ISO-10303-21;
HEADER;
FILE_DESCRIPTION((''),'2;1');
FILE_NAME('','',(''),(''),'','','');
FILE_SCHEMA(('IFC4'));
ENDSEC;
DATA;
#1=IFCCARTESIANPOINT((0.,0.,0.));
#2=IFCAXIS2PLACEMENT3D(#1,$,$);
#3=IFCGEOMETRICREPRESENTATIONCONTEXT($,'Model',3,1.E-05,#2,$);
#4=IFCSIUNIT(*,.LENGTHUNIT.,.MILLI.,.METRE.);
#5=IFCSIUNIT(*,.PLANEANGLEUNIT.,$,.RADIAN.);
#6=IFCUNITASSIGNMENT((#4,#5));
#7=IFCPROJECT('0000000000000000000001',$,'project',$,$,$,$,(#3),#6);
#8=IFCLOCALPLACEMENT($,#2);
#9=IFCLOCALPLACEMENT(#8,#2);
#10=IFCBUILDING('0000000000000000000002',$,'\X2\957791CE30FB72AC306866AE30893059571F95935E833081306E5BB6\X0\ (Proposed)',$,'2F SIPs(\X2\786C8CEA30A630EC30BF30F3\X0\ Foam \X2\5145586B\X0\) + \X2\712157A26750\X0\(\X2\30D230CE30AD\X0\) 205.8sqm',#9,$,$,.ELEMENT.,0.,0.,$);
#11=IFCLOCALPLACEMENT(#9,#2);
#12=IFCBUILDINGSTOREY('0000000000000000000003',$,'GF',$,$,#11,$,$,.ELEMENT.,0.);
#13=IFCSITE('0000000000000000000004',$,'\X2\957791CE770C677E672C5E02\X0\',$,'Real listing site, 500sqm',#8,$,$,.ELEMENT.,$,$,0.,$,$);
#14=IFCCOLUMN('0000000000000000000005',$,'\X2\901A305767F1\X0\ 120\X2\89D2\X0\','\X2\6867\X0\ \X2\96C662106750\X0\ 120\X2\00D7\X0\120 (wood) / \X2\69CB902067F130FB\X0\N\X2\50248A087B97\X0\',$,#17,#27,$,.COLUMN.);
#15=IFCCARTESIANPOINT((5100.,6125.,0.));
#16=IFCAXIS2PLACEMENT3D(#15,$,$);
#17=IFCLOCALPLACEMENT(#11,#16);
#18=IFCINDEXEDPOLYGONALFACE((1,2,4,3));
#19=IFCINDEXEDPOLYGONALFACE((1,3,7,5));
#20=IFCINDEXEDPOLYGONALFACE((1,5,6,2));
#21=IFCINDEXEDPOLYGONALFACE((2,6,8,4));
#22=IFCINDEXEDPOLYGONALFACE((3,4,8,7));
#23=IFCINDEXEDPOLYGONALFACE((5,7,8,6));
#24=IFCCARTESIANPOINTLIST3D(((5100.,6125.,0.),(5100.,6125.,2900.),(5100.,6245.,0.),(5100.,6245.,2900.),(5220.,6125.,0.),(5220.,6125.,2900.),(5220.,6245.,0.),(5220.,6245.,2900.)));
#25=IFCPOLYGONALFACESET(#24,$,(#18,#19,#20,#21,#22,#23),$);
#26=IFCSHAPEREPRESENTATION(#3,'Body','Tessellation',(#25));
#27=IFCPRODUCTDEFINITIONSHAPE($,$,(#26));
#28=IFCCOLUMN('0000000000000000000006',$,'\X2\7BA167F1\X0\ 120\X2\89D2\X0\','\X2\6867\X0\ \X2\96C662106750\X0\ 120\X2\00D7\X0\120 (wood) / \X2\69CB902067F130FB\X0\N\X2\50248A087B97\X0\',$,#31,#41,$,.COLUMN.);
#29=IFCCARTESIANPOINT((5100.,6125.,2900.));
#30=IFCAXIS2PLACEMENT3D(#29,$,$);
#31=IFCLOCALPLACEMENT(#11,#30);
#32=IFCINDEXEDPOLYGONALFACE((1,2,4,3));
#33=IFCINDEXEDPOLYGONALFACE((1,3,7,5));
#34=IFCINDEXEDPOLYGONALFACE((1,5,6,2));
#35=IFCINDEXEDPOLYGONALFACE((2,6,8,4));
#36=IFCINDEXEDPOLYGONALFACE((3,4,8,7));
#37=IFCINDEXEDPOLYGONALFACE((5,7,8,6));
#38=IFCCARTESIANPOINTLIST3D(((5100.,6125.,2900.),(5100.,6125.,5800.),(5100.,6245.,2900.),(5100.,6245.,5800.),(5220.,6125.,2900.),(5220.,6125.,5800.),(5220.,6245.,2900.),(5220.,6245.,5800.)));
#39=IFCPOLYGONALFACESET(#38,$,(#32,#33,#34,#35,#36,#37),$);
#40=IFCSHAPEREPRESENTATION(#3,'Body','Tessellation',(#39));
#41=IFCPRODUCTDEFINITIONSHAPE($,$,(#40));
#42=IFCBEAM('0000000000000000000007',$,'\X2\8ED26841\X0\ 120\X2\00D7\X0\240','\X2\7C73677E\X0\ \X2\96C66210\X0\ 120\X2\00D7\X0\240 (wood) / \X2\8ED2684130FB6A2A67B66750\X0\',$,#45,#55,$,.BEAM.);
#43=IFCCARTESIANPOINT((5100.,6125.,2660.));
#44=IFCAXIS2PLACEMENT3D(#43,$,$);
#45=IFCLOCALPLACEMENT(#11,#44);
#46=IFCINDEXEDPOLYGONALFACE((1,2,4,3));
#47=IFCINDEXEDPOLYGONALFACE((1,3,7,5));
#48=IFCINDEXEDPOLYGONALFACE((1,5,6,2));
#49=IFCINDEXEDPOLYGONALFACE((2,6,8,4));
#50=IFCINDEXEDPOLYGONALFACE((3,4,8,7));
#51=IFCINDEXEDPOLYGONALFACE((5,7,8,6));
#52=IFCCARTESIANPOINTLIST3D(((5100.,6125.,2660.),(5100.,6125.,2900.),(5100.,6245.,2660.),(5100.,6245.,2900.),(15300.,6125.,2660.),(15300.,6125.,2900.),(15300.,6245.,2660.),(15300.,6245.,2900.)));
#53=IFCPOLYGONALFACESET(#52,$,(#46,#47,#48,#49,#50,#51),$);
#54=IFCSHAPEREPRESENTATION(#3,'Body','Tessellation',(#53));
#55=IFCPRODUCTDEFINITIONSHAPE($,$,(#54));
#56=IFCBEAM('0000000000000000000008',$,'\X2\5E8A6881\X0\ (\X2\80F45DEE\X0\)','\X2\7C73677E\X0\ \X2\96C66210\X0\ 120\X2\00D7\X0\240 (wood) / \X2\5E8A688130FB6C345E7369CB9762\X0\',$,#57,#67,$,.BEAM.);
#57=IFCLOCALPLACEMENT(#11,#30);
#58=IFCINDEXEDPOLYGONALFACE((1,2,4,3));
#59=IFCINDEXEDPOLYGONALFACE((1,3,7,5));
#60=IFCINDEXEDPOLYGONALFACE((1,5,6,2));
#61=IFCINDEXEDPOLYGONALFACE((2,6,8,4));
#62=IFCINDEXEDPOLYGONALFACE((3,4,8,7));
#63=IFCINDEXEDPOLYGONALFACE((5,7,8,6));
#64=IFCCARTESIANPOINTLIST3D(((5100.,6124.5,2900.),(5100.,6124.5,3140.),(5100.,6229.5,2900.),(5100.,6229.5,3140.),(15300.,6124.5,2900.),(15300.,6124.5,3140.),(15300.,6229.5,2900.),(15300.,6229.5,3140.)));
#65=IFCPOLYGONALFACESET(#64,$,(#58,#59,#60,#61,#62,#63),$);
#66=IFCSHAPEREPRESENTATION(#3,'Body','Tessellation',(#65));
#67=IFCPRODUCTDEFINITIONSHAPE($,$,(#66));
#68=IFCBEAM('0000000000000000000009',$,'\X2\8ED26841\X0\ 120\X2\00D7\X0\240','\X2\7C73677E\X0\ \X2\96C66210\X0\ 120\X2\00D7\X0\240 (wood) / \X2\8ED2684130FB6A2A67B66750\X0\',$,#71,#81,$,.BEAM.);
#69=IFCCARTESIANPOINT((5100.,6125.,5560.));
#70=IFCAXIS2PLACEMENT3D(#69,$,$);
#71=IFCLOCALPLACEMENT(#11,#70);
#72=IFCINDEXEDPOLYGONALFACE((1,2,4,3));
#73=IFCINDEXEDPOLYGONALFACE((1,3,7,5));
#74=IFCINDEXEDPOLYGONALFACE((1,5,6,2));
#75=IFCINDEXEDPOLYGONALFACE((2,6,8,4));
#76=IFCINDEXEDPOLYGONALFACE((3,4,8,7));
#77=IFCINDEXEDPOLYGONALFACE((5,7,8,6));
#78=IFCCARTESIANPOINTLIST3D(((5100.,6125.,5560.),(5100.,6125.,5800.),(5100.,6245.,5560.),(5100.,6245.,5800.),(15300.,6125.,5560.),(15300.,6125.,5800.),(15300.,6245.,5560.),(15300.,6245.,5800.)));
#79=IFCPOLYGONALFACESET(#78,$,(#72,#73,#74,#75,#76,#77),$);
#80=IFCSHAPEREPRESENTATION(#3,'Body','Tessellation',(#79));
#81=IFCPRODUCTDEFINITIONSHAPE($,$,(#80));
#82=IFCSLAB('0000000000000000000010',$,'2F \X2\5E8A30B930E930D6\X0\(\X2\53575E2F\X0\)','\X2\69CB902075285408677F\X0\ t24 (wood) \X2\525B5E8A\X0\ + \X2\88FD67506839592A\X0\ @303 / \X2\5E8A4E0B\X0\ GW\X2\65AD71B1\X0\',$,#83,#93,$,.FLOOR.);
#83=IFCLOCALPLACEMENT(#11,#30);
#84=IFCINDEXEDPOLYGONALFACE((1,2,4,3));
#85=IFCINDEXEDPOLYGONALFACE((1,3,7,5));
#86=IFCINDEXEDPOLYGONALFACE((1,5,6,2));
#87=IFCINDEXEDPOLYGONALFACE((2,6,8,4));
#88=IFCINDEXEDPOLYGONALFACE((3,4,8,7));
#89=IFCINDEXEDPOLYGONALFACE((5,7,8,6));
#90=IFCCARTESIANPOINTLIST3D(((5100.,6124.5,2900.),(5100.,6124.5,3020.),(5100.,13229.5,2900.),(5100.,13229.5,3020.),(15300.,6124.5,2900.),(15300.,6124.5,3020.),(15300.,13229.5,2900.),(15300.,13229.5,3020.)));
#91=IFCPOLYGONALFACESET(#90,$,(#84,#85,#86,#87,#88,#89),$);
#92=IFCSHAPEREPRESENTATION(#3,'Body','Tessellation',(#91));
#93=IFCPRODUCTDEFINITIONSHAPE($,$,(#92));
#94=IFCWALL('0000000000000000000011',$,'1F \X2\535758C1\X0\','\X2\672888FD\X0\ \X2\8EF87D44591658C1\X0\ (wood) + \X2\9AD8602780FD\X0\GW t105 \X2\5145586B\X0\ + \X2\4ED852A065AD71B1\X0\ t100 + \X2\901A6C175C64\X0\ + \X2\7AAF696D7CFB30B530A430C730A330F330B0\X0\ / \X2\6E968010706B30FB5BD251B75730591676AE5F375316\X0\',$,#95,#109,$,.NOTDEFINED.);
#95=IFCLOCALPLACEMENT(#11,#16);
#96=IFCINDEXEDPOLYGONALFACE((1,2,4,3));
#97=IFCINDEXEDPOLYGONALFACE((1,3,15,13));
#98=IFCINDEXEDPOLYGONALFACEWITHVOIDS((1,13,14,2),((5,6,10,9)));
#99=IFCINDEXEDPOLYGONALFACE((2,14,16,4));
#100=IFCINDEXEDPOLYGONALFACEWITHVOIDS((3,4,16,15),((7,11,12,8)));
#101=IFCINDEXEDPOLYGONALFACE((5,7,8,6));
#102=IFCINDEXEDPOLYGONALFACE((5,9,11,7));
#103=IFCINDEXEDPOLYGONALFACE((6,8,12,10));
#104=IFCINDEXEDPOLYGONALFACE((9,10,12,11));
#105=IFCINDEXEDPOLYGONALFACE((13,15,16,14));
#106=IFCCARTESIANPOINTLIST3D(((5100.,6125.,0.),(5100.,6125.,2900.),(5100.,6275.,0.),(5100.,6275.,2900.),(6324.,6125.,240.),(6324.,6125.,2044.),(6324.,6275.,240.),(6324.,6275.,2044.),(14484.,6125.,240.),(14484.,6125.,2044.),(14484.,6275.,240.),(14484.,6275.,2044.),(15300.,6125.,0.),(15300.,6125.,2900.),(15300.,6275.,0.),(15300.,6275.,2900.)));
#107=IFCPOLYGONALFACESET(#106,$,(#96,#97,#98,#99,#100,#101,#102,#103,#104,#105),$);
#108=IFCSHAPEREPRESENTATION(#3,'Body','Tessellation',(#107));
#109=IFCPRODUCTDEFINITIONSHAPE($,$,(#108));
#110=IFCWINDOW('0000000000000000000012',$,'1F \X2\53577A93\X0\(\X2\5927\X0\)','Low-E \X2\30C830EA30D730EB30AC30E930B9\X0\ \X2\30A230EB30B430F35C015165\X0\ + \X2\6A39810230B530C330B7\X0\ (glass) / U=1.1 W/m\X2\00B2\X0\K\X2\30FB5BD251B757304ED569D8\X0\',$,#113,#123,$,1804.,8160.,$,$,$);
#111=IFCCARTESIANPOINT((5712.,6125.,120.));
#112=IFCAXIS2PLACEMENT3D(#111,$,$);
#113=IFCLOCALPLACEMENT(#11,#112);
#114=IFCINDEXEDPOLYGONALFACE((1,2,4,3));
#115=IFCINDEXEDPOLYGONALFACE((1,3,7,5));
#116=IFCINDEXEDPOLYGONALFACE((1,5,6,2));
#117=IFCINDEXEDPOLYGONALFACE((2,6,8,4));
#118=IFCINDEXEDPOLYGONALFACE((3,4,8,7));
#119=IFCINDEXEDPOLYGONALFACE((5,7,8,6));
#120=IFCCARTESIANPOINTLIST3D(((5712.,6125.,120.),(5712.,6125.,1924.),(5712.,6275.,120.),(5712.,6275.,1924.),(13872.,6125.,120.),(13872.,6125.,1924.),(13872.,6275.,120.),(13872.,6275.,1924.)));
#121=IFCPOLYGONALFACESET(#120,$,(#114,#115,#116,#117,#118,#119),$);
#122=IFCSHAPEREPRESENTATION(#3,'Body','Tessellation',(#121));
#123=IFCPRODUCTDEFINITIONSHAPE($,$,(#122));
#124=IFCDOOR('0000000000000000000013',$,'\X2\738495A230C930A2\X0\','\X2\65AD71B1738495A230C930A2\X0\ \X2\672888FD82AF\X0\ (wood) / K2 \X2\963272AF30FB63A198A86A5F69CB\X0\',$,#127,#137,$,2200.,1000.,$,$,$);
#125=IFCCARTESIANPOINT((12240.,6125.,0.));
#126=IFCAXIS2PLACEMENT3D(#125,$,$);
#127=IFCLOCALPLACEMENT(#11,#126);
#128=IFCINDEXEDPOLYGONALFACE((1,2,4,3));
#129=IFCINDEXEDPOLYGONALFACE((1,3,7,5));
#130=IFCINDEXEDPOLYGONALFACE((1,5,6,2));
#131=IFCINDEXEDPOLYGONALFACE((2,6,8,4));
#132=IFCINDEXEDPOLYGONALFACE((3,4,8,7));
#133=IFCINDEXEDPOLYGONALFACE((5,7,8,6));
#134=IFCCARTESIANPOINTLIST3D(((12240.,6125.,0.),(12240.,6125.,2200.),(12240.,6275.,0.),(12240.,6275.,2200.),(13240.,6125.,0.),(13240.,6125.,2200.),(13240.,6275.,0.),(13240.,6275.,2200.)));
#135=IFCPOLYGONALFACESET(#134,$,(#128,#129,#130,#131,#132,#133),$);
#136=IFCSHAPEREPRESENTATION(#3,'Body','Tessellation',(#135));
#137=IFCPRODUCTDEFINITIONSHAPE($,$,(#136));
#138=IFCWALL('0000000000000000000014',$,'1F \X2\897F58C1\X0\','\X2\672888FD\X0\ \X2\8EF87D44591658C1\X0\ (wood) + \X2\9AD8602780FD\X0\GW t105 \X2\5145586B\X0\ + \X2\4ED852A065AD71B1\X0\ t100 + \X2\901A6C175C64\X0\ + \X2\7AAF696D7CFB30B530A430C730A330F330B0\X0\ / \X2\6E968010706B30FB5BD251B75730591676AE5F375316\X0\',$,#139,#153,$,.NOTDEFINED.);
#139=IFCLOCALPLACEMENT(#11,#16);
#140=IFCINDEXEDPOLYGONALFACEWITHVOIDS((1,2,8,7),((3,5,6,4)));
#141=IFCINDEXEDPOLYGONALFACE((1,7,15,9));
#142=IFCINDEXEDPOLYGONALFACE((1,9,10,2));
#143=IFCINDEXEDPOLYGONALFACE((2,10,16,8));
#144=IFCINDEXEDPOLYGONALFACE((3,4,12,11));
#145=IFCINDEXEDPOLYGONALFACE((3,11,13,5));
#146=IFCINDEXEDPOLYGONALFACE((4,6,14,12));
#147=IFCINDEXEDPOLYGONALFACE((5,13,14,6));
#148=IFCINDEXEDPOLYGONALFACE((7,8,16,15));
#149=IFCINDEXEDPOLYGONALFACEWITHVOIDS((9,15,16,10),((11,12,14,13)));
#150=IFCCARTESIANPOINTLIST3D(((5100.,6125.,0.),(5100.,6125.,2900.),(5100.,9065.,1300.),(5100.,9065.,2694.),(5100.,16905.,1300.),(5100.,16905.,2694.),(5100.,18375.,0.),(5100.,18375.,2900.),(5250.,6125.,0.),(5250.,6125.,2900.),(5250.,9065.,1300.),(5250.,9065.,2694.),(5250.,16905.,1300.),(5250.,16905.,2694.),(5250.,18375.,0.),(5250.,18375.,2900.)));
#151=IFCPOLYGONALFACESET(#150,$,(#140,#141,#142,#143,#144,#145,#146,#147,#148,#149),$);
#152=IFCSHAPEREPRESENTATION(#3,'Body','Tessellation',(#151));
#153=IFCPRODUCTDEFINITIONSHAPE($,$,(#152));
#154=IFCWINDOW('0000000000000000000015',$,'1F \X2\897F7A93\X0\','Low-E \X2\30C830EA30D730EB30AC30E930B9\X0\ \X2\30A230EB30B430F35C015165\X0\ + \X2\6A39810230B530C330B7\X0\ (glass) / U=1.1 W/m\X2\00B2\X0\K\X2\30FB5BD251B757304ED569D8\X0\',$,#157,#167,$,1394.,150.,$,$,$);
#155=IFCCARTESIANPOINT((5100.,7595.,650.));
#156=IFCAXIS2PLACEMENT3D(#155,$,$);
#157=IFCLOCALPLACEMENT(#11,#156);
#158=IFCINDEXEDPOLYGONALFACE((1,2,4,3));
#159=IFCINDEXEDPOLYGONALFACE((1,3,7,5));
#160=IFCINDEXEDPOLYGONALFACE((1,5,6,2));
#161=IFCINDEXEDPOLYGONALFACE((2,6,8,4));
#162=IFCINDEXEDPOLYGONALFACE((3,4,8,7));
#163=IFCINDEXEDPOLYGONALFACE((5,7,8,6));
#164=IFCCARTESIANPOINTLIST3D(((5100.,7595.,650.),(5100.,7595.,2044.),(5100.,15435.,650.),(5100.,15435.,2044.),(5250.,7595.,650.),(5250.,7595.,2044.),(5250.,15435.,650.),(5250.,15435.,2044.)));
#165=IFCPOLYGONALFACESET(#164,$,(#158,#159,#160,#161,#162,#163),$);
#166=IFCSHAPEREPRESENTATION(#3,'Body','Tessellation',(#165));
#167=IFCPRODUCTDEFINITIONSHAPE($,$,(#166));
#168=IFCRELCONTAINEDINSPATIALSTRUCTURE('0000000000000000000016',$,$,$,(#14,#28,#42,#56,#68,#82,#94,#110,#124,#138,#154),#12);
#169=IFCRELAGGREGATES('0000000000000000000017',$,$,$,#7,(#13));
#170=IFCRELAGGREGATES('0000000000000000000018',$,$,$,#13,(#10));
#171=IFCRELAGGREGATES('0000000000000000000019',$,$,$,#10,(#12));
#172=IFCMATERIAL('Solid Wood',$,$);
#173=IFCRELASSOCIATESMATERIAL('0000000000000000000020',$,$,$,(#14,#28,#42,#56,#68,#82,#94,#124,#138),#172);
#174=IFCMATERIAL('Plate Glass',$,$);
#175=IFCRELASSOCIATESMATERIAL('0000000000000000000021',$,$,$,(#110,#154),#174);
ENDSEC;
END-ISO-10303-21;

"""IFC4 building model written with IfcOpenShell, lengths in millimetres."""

from ifc_helpers import new_model, si_unit, frame, frame_2d, origin, place, context, project, spatial, rectangle, extrude, material, element, fill, save


model = new_model("IFC4")

# Units and contexts
model_context = context("Model", 3, precision=1e-05, world=origin())
ifc_project = project(units=[si_unit("LENGTHUNIT", "METRE", prefix="MILLI"), si_unit("PLANEANGLEUNIT", "RADIAN")], contexts=[model_context])

# Site, building, storey
site_placement = place(None, origin())
site = spatial("IfcSite", under=ifc_project, at=site_placement, Name="長野県松本市", ObjectType="Real listing site, 500sqm", CompositionType="ELEMENT", RefElevation=0.0)
building_placement = place(site_placement, origin())
building = spatial("IfcBuilding", under=site, at=building_placement, Name="長野・犬と暮らす土間広めの家 (Proposed)", ObjectType="2F SIPs(硬質ウレタン Foam 充填) + 無垢材(ヒノキ) 205.8sqm", CompositionType="ELEMENT", ElevationOfRefHeight=0.0, ElevationOfTerrain=0.0)
storey_placement = place(building_placement, origin())
storey = spatial("IfcBuildingStorey", under=building, at=storey_placement, Name="GF", CompositionType="ELEMENT", Elevation=0.0)

# Columns
ifc_material_1 = material(Name="Solid Wood")
column_1_placement = place(storey_placement, frame((5100.0, 6125.0, 0.0)))
element("IfcColumn", 1, at=column_1_placement, inside=storey, material=ifc_material_1, Name="通し柱 120角", Description="桧 集成材 120×120 (wood) / 構造柱・N値計算", PredefinedType="COLUMN", context=model_context, shape_type="SweptSolid", body=[
    extrude(rectangle(XDim=120.0, YDim=120.0, at=frame_2d((60.0, 60.0))), frame((5100.0, 6125.0, 0.0)), (0.0, 0.0, 1.0), 2900.0),
])
column_2_placement = place(storey_placement, frame((5100.0, 6125.0, 2900.0)))
element("IfcColumn", 2, at=column_2_placement, inside=storey, material=ifc_material_1, Name="管柱 120角", Description="桧 集成材 120×120 (wood) / 構造柱・N値計算", PredefinedType="COLUMN", context=model_context, shape_type="SweptSolid", body=[
    extrude(rectangle(XDim=120.0, YDim=120.0, at=frame_2d((60.0, 60.0))), frame((5100.0, 6125.0, 2900.0)), (0.0, 0.0, 1.0), 2900.0),
])

# Beams
beam_1_placement = place(storey_placement, frame((5100.0, 6125.0, 2660.0)))
element("IfcBeam", 3, at=beam_1_placement, inside=storey, material=ifc_material_1, Name="軒桁 120×240", Description="米松 集成 120×240 (wood) / 軒桁・横架材", PredefinedType="BEAM", context=model_context, shape_type="SweptSolid", body=[
    extrude(rectangle(XDim=10200.0, YDim=120.0, at=frame_2d((5100.0, 60.0))), frame((5100.0, 6125.0, 2660.0)), (0.0, 0.0, 1.0), 240.0),
])
beam_2_placement = place(storey_placement, frame((5100.0, 6125.0, 2900.0)))
element("IfcBeam", 4, at=beam_2_placement, inside=storey, material=ifc_material_1, Name="床梁 (胴差)", Description="米松 集成 120×240 (wood) / 床梁・水平構面", PredefinedType="BEAM", context=model_context, shape_type="SweptSolid", body=[
    extrude(rectangle(XDim=10200.0, YDim=105.0, at=frame_2d((5100.0, 52.0))), frame((5100.0, 6125.0, 2900.0)), (0.0, 0.0, 1.0), 240.0),
])
beam_3_placement = place(storey_placement, frame((5100.0, 6125.0, 5560.0)))
element("IfcBeam", 5, at=beam_3_placement, inside=storey, material=ifc_material_1, Name="軒桁 120×240", Description="米松 集成 120×240 (wood) / 軒桁・横架材", PredefinedType="BEAM", context=model_context, shape_type="SweptSolid", body=[
    extrude(rectangle(XDim=10200.0, YDim=120.0, at=frame_2d((5100.0, 60.0))), frame((5100.0, 6125.0, 5560.0)), (0.0, 0.0, 1.0), 240.0),
])

# Slab
slab_1_placement = place(storey_placement, frame((5100.0, 6125.0, 2900.0)))
element("IfcSlab", 6, at=slab_1_placement, inside=storey, material=ifc_material_1, Name="2F 床スラブ(南帯)", Description="構造用合板 t24 (wood) 剛床 + 製材根太 @303 / 床下 GW断熱", PredefinedType="FLOOR", context=model_context, shape_type="SweptSolid", body=[
    extrude(rectangle(XDim=10200.0, YDim=7105.0, at=frame_2d((5100.0, 3552.0))), frame((5100.0, 6125.0, 2900.0)), (0.0, 0.0, 1.0), 120.0),
])

# Wall, openings, window, door
wall_1_placement = place(storey_placement, frame((5100.0, 6125.0, 0.0)))
wall_1 = element("IfcWall", 7, at=wall_1_placement, inside=storey, material=ifc_material_1, Name="1F 南壁", Description="木製 軸組外壁 (wood) + 高性能GW t105 充填 + 付加断熱 t100 + 通気層 + 窯業系サイディング / 準耐火・寒冷地外皮強化", PredefinedType="NOTDEFINED", context=model_context, shape_type="SweptSolid", body=[
    extrude(rectangle(XDim=10200.0, YDim=150.0, at=frame_2d((5100.0, 75.0))), frame((5100.0, 6125.0, 0.0)), (0.0, 0.0, 1.0), 2900.0),
])
opening_1_placement = place(storey_placement, frame((5712.0, 6125.0, 120.0)))
opening_1 = element("IfcOpeningElement", 8, at=opening_1_placement, cuts=wall_1, PredefinedType="NOTDEFINED", context=model_context, shape_type="SweptSolid", body=[
    extrude(rectangle(XDim=8160.0, YDim=150.0, at=frame_2d((4080.0, 75.0))), frame((5712.0, 6125.0, 120.0)), (0.0, 0.0, 1.0), 1804.0),
])
opening_2_placement = place(storey_placement, frame((12240.0, 6125.0, 0.0)))
opening_2 = element("IfcOpeningElement", 9, at=opening_2_placement, cuts=wall_1, PredefinedType="NOTDEFINED", context=model_context, shape_type="SweptSolid", body=[
    extrude(rectangle(XDim=1000.0, YDim=150.0, at=frame_2d((500.0, 75.0))), frame((12240.0, 6125.0, 0.0)), (0.0, 0.0, 1.0), 2200.0),
])
ifc_material_2 = material(Name="Plate Glass")
window_1_placement = place(storey_placement, frame((5712.0, 6125.0, 120.0)))
window_1 = element("IfcWindow", 10, at=window_1_placement, inside=storey, material=ifc_material_2, Name="1F 南窓(大)", Description="Low-E トリプルガラス アルゴン封入 + 樹脂サッシ (glass) / U=1.1 W/m²K・寒冷地仕様", OverallHeight=1804.0, OverallWidth=8160.0, context=model_context, shape_type="SweptSolid", body=[
    extrude(rectangle(XDim=8160.0, YDim=150.0, at=frame_2d((4080.0, 75.0))), frame((5712.0, 6125.0, 120.0)), (0.0, 0.0, 1.0), 1804.0),
])
fill(opening_1, window_1)
door_placement = place(storey_placement, frame((12240.0, 6125.0, 0.0)))
door = element("IfcDoor", 11, at=door_placement, inside=storey, material=ifc_material_1, Name="玄関ドア", Description="断熱玄関ドア 木製芯 (wood) / K2 防犯・採風機構", OverallHeight=2200.0, OverallWidth=1000.0, context=model_context, shape_type="SweptSolid", body=[
    extrude(rectangle(XDim=1000.0, YDim=150.0, at=frame_2d((500.0, 75.0))), frame((12240.0, 6125.0, 0.0)), (0.0, 0.0, 1.0), 2200.0),
])
fill(opening_2, door)

# Wall, opening, window
wall_2_placement = place(storey_placement, frame((5100.0, 6125.0, 0.0)))
wall_2 = element("IfcWall", 12, at=wall_2_placement, inside=storey, material=ifc_material_1, Name="1F 西壁", Description="木製 軸組外壁 (wood) + 高性能GW t105 充填 + 付加断熱 t100 + 通気層 + 窯業系サイディング / 準耐火・寒冷地外皮強化", PredefinedType="NOTDEFINED", context=model_context, shape_type="SweptSolid", body=[
    extrude(rectangle(XDim=150.0, YDim=12250.0, at=frame_2d((75.0, 6125.0))), frame((5100.0, 6125.0, 0.0)), (0.0, 0.0, 1.0), 2900.0),
])
opening_3_placement = place(storey_placement, frame((5100.0, 7595.0, 650.0)))
opening_3 = element("IfcOpeningElement", 13, at=opening_3_placement, cuts=wall_2, PredefinedType="NOTDEFINED", context=model_context, shape_type="SweptSolid", body=[
    extrude(rectangle(XDim=150.0, YDim=7840.0, at=frame_2d((75.0, 3920.0))), frame((5100.0, 7595.0, 650.0)), (0.0, 0.0, 1.0), 1394.0),
])
window_2_placement = place(storey_placement, frame((5100.0, 7595.0, 650.0)))
window_2 = element("IfcWindow", 14, at=window_2_placement, inside=storey, material=ifc_material_2, Name="1F 西窓", Description="Low-E トリプルガラス アルゴン封入 + 樹脂サッシ (glass) / U=1.1 W/m²K・寒冷地仕様", OverallHeight=1394.0, OverallWidth=150.0, context=model_context, shape_type="SweptSolid", body=[
    extrude(rectangle(XDim=150.0, YDim=7840.0, at=frame_2d((75.0, 3920.0))), frame((5100.0, 7595.0, 650.0)), (0.0, 0.0, 1.0), 1394.0),
])
fill(opening_3, window_2)

save(model, "model.ifc")
